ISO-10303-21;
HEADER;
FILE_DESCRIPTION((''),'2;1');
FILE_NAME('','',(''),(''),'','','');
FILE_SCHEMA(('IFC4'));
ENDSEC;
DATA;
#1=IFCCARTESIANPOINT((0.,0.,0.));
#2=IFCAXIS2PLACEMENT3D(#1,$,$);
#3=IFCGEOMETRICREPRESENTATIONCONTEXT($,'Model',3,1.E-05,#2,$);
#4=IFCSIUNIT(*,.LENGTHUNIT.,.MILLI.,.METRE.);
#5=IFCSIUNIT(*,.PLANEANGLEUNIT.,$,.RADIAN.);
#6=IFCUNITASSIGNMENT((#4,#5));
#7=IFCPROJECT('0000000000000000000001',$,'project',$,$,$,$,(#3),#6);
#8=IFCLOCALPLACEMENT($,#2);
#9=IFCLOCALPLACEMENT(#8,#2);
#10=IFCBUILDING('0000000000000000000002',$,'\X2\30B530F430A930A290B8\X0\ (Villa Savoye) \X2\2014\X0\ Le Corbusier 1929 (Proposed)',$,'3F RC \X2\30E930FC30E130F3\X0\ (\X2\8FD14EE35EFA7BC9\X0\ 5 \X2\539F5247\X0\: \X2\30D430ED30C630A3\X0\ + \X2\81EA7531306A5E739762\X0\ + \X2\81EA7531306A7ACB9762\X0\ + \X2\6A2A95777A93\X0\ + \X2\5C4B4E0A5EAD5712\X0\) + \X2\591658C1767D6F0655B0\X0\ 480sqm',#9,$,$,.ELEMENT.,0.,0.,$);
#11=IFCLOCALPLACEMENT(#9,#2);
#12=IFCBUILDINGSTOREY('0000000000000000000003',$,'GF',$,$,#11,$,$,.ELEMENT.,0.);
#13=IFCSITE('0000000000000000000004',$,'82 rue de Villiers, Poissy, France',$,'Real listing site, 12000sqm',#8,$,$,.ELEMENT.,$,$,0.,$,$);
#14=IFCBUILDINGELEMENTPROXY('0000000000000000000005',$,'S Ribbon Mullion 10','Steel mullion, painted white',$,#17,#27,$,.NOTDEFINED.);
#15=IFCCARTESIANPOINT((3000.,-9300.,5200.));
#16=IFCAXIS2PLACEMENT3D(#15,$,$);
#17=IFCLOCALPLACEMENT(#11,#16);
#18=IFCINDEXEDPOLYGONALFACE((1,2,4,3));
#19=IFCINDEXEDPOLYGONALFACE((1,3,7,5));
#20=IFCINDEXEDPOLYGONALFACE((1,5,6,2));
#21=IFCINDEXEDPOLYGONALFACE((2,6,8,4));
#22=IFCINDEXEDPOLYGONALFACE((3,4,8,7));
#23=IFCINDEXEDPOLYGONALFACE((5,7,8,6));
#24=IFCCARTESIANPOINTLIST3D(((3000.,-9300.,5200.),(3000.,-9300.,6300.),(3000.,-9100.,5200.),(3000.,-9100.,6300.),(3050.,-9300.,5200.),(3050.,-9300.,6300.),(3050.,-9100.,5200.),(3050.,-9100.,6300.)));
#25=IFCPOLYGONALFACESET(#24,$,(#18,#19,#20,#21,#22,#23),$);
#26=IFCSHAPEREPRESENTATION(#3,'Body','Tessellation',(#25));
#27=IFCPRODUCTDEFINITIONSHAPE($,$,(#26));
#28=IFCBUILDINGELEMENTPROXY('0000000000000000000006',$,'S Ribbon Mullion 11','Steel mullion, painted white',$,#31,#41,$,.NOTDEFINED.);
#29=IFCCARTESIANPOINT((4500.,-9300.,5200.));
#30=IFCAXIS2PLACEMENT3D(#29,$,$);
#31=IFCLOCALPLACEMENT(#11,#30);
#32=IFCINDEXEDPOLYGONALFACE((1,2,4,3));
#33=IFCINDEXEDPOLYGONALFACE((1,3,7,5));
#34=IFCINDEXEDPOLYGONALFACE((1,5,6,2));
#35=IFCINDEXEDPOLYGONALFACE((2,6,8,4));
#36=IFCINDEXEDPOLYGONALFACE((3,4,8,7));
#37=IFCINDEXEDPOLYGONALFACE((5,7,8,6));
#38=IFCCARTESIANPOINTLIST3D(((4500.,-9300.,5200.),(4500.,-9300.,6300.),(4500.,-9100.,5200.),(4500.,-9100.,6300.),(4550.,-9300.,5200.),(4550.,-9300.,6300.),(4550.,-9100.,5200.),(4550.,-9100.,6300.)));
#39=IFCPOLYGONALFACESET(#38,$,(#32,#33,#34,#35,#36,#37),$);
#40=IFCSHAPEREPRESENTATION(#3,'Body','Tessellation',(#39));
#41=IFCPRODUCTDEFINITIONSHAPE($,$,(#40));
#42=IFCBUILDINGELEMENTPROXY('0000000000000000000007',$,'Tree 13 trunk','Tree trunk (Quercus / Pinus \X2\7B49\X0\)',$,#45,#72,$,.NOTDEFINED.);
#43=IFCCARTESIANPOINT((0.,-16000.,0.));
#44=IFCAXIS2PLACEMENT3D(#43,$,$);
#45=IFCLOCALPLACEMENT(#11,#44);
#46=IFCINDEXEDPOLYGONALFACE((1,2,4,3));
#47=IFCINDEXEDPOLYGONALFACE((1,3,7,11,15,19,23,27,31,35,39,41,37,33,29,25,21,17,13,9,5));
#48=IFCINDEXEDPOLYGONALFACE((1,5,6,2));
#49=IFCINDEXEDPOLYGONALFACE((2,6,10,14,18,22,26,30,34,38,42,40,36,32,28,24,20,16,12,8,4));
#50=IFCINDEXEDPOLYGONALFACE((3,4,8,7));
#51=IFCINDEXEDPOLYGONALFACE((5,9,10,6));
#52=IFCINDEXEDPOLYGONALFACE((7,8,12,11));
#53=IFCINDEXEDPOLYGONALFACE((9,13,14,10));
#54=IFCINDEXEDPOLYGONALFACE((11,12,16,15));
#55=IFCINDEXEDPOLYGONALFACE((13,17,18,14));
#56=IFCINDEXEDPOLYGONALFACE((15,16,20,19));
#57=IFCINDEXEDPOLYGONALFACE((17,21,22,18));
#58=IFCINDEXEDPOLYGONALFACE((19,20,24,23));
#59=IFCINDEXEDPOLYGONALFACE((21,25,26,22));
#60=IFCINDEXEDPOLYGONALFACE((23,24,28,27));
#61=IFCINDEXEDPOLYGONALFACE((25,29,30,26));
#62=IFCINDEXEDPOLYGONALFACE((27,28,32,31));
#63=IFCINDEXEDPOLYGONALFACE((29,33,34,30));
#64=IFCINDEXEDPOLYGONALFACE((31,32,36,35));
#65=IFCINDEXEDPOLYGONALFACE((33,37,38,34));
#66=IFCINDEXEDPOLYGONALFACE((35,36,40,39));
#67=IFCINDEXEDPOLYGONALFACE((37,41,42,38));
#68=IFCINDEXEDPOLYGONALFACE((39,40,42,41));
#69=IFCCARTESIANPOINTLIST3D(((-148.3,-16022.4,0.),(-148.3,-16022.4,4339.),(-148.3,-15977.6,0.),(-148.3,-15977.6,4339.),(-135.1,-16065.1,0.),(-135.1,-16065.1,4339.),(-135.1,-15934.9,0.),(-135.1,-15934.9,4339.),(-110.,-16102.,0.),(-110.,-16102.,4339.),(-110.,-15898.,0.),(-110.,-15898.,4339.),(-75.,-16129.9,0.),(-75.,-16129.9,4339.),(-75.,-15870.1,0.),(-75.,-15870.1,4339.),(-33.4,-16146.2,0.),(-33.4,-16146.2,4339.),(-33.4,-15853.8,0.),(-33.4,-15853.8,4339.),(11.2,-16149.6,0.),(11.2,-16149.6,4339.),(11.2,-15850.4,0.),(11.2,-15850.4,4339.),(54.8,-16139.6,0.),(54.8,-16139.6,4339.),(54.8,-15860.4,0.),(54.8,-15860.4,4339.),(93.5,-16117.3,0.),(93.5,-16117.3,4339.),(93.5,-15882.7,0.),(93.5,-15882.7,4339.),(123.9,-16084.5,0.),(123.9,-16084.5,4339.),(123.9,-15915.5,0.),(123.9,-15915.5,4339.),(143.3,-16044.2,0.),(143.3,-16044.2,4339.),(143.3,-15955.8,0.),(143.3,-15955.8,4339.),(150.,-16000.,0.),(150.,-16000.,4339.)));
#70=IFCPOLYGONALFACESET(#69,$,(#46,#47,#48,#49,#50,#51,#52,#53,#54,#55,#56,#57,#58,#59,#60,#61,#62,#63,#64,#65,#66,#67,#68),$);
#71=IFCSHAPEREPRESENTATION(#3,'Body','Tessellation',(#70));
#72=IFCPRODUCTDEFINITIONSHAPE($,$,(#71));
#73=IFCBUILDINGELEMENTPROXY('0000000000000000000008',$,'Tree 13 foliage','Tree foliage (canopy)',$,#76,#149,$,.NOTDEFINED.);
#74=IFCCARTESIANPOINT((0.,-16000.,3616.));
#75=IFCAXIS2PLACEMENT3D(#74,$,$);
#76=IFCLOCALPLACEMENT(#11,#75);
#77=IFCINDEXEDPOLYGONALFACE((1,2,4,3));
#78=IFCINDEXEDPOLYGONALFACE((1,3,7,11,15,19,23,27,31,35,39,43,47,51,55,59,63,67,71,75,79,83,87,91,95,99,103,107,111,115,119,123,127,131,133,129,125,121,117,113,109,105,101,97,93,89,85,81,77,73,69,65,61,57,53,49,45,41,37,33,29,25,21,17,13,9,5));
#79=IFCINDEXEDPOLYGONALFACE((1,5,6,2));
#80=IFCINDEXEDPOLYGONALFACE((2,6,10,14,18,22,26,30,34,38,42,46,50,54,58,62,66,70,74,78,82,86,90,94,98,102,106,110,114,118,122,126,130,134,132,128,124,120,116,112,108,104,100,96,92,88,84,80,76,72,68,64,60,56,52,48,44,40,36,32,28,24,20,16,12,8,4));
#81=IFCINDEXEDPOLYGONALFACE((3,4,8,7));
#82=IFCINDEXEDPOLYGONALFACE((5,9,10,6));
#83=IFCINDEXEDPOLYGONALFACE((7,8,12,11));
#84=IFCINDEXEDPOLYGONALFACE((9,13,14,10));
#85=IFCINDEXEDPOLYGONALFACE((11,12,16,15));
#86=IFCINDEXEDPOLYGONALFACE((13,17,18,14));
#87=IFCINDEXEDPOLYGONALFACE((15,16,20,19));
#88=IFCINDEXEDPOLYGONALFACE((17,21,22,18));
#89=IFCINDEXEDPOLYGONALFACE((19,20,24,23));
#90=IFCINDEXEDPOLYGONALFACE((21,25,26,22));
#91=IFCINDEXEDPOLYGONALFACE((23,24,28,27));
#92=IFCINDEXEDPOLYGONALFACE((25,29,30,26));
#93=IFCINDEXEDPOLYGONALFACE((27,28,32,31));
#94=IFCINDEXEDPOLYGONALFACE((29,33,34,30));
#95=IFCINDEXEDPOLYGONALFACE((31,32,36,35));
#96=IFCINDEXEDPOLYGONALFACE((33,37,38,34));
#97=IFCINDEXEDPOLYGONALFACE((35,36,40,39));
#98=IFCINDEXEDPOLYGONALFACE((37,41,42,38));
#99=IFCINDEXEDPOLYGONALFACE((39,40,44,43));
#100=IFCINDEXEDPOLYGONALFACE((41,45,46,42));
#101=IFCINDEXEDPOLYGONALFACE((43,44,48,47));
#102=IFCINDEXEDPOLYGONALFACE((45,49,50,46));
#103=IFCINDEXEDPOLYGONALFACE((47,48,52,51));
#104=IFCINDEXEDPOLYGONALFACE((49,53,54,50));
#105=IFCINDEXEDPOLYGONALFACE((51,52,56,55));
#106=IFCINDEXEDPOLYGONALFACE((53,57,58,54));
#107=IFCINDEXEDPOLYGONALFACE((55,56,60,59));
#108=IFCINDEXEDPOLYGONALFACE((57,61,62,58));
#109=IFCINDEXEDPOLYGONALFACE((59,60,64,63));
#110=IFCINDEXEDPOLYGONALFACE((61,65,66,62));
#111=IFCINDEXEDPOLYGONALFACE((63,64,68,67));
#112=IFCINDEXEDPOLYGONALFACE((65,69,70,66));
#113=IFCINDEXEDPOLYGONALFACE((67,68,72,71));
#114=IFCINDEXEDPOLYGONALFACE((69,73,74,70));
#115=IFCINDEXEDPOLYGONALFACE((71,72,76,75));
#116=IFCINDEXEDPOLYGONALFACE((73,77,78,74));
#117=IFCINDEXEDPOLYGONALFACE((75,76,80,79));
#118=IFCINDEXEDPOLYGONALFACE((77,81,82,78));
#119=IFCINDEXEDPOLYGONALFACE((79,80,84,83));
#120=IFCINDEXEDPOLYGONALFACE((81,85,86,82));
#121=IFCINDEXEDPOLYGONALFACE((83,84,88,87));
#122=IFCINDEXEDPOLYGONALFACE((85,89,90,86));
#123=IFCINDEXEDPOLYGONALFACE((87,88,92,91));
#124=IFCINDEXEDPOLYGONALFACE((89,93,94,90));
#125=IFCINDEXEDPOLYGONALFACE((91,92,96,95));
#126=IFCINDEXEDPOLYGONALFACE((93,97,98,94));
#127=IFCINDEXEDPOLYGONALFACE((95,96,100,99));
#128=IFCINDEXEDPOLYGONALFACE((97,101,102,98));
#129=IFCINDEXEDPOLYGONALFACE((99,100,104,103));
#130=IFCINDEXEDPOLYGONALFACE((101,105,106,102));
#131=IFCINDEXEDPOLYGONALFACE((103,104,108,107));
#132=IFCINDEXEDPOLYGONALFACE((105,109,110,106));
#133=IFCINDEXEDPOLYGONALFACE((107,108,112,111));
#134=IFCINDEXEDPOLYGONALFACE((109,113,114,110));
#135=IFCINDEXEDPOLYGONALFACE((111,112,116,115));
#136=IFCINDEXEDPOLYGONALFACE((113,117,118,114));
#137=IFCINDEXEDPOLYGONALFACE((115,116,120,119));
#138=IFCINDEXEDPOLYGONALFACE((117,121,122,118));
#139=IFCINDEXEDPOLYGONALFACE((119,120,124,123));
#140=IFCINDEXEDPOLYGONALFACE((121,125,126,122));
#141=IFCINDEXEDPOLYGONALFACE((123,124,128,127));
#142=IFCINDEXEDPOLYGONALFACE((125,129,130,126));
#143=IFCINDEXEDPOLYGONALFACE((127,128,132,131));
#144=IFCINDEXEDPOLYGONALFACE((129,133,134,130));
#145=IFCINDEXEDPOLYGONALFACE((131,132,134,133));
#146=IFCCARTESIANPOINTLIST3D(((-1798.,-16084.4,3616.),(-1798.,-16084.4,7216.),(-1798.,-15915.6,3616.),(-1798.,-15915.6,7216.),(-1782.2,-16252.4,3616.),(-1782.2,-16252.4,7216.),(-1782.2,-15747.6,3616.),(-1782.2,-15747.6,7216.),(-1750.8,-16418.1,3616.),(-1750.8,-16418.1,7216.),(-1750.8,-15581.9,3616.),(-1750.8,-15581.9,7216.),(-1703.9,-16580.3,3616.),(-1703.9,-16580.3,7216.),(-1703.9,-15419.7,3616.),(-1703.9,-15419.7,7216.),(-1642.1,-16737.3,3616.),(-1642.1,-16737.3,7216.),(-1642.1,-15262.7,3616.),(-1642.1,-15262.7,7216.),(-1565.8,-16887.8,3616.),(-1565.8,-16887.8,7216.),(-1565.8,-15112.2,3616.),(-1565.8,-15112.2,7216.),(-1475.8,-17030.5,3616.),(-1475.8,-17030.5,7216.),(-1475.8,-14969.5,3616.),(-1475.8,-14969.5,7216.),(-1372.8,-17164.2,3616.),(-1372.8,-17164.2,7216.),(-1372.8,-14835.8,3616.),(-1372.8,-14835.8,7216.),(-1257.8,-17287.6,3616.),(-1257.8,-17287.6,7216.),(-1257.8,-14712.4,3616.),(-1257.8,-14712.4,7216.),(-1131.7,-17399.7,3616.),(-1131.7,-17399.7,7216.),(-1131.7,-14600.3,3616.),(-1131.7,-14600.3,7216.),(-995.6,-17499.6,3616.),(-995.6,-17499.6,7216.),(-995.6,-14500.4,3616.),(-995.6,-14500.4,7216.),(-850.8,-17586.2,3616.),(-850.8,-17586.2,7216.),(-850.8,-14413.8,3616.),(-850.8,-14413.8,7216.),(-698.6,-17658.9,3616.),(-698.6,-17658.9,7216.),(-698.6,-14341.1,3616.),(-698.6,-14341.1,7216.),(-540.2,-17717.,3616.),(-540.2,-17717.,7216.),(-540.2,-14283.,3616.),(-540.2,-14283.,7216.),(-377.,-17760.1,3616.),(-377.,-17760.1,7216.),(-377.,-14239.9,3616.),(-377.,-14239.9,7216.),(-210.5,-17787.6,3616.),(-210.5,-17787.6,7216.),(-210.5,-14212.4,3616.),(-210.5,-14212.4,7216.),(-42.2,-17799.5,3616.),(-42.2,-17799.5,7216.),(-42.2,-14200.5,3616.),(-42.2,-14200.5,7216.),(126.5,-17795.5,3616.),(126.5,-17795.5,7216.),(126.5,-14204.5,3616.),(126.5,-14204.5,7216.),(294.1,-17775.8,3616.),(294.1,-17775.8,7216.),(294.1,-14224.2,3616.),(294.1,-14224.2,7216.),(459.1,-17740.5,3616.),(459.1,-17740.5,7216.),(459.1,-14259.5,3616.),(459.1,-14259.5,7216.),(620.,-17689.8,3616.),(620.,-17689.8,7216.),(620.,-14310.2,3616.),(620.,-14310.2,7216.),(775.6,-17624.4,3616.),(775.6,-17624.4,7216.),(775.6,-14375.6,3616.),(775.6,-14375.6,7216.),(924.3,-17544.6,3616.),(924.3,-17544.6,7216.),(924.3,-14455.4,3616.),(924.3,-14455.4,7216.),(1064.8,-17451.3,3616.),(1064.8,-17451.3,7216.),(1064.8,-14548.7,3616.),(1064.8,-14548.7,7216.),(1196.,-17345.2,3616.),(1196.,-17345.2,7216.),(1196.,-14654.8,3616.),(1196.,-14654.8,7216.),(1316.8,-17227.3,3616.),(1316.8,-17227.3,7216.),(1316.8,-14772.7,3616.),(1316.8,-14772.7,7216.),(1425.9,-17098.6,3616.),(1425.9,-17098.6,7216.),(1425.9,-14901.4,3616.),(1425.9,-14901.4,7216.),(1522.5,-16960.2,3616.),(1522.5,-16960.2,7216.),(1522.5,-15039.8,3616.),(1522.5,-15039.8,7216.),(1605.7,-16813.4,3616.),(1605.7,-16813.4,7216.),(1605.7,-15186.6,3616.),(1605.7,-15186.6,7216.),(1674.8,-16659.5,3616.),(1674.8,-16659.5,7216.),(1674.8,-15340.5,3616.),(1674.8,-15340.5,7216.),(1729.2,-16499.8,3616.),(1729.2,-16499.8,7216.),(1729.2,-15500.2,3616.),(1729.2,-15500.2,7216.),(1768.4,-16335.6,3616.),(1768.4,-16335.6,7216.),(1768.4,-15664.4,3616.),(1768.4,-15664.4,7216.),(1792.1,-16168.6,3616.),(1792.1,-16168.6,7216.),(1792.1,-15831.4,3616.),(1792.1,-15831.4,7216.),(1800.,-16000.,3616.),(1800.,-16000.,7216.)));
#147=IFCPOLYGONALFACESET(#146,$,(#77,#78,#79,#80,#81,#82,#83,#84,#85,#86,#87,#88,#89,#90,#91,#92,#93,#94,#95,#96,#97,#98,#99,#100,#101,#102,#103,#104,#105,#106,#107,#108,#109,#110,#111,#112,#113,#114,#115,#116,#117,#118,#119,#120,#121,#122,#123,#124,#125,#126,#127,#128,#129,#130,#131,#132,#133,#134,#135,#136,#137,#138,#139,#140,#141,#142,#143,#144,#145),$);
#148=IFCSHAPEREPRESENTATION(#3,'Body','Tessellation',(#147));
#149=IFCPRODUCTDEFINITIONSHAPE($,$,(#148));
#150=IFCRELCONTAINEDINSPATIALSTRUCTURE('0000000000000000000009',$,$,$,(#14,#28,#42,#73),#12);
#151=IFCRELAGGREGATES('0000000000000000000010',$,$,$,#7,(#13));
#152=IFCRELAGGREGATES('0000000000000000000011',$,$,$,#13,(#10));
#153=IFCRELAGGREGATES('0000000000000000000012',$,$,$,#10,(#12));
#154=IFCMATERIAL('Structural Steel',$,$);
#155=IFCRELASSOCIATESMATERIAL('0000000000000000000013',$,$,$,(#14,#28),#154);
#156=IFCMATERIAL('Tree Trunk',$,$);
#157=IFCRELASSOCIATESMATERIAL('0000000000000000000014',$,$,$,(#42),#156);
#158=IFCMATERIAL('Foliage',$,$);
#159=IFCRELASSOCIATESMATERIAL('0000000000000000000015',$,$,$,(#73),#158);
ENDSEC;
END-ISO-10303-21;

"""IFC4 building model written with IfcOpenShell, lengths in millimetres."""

from ifc_helpers import new_model, si_unit, frame, frame_2d, origin, origin_2d, place, context, project, spatial, rectangle, circle, extrude, material, element, save


model = new_model("IFC4")

# Units and contexts
model_context = context("Model", 3, precision=1e-05, world=origin())
ifc_project = project(units=[si_unit("LENGTHUNIT", "METRE", prefix="MILLI"), si_unit("PLANEANGLEUNIT", "RADIAN")], contexts=[model_context])

# Site, building, storey
site_placement = place(None, origin())
site = spatial("IfcSite", under=ifc_project, at=site_placement, Name="82 rue de Villiers, Poissy, France", ObjectType="Real listing site, 12000sqm", CompositionType="ELEMENT", RefElevation=0.0)
building_placement = place(site_placement, origin())
building = spatial("IfcBuilding", under=site, at=building_placement, Name="サヴォア邸 (Villa Savoye) — Le Corbusier 1929 (Proposed)", ObjectType="3F RC ラーメン (近代建築 5 原則: ピロティ + 自由な平面 + 自由な立面 + 横長窓 + 屋上庭園) + 外壁白漆喰 480sqm", CompositionType="ELEMENT", ElevationOfRefHeight=0.0, ElevationOfTerrain=0.0)
storey_placement = place(building_placement, origin())
storey = spatial("IfcBuildingStorey", under=building, at=storey_placement, Name="GF", CompositionType="ELEMENT", Elevation=0.0)

# Building element proxies
ifc_material_1 = material(Name="Structural Steel")
proxy_1_placement = place(storey_placement, frame((3000.0, -9300.0, 5200.0)))
element("IfcBuildingElementProxy", 1, at=proxy_1_placement, inside=storey, material=ifc_material_1, Name="S Ribbon Mullion 10", Description="Steel mullion, painted white", PredefinedType="NOTDEFINED", context=model_context, shape_type="SweptSolid", body=[
    extrude(rectangle(XDim=50.0, YDim=200.0, at=frame_2d((25.0, 100.0))), frame((3000.0, -9300.0, 5200.0)), (0.0, 0.0, 1.0), 1100.0),
])
proxy_2_placement = place(storey_placement, frame((4500.0, -9300.0, 5200.0)))
element("IfcBuildingElementProxy", 2, at=proxy_2_placement, inside=storey, material=ifc_material_1, Name="S Ribbon Mullion 11", Description="Steel mullion, painted white", PredefinedType="NOTDEFINED", context=model_context, shape_type="SweptSolid", body=[
    extrude(rectangle(XDim=50.0, YDim=200.0, at=frame_2d((25.0, 100.0))), frame((4500.0, -9300.0, 5200.0)), (0.0, 0.0, 1.0), 1100.0),
])
ifc_material_2 = material(Name="Tree Trunk")
proxy_3_placement = place(storey_placement, frame((0.0, -16000.0, 0.0)))
element("IfcBuildingElementProxy", 3, at=proxy_3_placement, inside=storey, material=ifc_material_2, Name="Tree 13 trunk", Description="Tree trunk (Quercus / Pinus 等)", PredefinedType="NOTDEFINED", context=model_context, shape_type="SweptSolid", body=[
    extrude(circle(Radius=150.0, at=origin_2d()), frame((0.0, -16000.0, 0.0)), (0.0, 0.0, 1.0), 4339.0),
])
ifc_material_3 = material(Name="Foliage")
proxy_4_placement = place(storey_placement, frame((0.0, -16000.0, 3616.0)))
element("IfcBuildingElementProxy", 4, at=proxy_4_placement, inside=storey, material=ifc_material_3, Name="Tree 13 foliage", Description="Tree foliage (canopy)", PredefinedType="NOTDEFINED", context=model_context, shape_type="SweptSolid", body=[
    extrude(circle(Radius=1800.0, at=origin_2d()), frame((0.0, -16000.0, 3616.0)), (0.0, 0.0, 1.0), 3600.0),
])

save(model, "model.ifc")
